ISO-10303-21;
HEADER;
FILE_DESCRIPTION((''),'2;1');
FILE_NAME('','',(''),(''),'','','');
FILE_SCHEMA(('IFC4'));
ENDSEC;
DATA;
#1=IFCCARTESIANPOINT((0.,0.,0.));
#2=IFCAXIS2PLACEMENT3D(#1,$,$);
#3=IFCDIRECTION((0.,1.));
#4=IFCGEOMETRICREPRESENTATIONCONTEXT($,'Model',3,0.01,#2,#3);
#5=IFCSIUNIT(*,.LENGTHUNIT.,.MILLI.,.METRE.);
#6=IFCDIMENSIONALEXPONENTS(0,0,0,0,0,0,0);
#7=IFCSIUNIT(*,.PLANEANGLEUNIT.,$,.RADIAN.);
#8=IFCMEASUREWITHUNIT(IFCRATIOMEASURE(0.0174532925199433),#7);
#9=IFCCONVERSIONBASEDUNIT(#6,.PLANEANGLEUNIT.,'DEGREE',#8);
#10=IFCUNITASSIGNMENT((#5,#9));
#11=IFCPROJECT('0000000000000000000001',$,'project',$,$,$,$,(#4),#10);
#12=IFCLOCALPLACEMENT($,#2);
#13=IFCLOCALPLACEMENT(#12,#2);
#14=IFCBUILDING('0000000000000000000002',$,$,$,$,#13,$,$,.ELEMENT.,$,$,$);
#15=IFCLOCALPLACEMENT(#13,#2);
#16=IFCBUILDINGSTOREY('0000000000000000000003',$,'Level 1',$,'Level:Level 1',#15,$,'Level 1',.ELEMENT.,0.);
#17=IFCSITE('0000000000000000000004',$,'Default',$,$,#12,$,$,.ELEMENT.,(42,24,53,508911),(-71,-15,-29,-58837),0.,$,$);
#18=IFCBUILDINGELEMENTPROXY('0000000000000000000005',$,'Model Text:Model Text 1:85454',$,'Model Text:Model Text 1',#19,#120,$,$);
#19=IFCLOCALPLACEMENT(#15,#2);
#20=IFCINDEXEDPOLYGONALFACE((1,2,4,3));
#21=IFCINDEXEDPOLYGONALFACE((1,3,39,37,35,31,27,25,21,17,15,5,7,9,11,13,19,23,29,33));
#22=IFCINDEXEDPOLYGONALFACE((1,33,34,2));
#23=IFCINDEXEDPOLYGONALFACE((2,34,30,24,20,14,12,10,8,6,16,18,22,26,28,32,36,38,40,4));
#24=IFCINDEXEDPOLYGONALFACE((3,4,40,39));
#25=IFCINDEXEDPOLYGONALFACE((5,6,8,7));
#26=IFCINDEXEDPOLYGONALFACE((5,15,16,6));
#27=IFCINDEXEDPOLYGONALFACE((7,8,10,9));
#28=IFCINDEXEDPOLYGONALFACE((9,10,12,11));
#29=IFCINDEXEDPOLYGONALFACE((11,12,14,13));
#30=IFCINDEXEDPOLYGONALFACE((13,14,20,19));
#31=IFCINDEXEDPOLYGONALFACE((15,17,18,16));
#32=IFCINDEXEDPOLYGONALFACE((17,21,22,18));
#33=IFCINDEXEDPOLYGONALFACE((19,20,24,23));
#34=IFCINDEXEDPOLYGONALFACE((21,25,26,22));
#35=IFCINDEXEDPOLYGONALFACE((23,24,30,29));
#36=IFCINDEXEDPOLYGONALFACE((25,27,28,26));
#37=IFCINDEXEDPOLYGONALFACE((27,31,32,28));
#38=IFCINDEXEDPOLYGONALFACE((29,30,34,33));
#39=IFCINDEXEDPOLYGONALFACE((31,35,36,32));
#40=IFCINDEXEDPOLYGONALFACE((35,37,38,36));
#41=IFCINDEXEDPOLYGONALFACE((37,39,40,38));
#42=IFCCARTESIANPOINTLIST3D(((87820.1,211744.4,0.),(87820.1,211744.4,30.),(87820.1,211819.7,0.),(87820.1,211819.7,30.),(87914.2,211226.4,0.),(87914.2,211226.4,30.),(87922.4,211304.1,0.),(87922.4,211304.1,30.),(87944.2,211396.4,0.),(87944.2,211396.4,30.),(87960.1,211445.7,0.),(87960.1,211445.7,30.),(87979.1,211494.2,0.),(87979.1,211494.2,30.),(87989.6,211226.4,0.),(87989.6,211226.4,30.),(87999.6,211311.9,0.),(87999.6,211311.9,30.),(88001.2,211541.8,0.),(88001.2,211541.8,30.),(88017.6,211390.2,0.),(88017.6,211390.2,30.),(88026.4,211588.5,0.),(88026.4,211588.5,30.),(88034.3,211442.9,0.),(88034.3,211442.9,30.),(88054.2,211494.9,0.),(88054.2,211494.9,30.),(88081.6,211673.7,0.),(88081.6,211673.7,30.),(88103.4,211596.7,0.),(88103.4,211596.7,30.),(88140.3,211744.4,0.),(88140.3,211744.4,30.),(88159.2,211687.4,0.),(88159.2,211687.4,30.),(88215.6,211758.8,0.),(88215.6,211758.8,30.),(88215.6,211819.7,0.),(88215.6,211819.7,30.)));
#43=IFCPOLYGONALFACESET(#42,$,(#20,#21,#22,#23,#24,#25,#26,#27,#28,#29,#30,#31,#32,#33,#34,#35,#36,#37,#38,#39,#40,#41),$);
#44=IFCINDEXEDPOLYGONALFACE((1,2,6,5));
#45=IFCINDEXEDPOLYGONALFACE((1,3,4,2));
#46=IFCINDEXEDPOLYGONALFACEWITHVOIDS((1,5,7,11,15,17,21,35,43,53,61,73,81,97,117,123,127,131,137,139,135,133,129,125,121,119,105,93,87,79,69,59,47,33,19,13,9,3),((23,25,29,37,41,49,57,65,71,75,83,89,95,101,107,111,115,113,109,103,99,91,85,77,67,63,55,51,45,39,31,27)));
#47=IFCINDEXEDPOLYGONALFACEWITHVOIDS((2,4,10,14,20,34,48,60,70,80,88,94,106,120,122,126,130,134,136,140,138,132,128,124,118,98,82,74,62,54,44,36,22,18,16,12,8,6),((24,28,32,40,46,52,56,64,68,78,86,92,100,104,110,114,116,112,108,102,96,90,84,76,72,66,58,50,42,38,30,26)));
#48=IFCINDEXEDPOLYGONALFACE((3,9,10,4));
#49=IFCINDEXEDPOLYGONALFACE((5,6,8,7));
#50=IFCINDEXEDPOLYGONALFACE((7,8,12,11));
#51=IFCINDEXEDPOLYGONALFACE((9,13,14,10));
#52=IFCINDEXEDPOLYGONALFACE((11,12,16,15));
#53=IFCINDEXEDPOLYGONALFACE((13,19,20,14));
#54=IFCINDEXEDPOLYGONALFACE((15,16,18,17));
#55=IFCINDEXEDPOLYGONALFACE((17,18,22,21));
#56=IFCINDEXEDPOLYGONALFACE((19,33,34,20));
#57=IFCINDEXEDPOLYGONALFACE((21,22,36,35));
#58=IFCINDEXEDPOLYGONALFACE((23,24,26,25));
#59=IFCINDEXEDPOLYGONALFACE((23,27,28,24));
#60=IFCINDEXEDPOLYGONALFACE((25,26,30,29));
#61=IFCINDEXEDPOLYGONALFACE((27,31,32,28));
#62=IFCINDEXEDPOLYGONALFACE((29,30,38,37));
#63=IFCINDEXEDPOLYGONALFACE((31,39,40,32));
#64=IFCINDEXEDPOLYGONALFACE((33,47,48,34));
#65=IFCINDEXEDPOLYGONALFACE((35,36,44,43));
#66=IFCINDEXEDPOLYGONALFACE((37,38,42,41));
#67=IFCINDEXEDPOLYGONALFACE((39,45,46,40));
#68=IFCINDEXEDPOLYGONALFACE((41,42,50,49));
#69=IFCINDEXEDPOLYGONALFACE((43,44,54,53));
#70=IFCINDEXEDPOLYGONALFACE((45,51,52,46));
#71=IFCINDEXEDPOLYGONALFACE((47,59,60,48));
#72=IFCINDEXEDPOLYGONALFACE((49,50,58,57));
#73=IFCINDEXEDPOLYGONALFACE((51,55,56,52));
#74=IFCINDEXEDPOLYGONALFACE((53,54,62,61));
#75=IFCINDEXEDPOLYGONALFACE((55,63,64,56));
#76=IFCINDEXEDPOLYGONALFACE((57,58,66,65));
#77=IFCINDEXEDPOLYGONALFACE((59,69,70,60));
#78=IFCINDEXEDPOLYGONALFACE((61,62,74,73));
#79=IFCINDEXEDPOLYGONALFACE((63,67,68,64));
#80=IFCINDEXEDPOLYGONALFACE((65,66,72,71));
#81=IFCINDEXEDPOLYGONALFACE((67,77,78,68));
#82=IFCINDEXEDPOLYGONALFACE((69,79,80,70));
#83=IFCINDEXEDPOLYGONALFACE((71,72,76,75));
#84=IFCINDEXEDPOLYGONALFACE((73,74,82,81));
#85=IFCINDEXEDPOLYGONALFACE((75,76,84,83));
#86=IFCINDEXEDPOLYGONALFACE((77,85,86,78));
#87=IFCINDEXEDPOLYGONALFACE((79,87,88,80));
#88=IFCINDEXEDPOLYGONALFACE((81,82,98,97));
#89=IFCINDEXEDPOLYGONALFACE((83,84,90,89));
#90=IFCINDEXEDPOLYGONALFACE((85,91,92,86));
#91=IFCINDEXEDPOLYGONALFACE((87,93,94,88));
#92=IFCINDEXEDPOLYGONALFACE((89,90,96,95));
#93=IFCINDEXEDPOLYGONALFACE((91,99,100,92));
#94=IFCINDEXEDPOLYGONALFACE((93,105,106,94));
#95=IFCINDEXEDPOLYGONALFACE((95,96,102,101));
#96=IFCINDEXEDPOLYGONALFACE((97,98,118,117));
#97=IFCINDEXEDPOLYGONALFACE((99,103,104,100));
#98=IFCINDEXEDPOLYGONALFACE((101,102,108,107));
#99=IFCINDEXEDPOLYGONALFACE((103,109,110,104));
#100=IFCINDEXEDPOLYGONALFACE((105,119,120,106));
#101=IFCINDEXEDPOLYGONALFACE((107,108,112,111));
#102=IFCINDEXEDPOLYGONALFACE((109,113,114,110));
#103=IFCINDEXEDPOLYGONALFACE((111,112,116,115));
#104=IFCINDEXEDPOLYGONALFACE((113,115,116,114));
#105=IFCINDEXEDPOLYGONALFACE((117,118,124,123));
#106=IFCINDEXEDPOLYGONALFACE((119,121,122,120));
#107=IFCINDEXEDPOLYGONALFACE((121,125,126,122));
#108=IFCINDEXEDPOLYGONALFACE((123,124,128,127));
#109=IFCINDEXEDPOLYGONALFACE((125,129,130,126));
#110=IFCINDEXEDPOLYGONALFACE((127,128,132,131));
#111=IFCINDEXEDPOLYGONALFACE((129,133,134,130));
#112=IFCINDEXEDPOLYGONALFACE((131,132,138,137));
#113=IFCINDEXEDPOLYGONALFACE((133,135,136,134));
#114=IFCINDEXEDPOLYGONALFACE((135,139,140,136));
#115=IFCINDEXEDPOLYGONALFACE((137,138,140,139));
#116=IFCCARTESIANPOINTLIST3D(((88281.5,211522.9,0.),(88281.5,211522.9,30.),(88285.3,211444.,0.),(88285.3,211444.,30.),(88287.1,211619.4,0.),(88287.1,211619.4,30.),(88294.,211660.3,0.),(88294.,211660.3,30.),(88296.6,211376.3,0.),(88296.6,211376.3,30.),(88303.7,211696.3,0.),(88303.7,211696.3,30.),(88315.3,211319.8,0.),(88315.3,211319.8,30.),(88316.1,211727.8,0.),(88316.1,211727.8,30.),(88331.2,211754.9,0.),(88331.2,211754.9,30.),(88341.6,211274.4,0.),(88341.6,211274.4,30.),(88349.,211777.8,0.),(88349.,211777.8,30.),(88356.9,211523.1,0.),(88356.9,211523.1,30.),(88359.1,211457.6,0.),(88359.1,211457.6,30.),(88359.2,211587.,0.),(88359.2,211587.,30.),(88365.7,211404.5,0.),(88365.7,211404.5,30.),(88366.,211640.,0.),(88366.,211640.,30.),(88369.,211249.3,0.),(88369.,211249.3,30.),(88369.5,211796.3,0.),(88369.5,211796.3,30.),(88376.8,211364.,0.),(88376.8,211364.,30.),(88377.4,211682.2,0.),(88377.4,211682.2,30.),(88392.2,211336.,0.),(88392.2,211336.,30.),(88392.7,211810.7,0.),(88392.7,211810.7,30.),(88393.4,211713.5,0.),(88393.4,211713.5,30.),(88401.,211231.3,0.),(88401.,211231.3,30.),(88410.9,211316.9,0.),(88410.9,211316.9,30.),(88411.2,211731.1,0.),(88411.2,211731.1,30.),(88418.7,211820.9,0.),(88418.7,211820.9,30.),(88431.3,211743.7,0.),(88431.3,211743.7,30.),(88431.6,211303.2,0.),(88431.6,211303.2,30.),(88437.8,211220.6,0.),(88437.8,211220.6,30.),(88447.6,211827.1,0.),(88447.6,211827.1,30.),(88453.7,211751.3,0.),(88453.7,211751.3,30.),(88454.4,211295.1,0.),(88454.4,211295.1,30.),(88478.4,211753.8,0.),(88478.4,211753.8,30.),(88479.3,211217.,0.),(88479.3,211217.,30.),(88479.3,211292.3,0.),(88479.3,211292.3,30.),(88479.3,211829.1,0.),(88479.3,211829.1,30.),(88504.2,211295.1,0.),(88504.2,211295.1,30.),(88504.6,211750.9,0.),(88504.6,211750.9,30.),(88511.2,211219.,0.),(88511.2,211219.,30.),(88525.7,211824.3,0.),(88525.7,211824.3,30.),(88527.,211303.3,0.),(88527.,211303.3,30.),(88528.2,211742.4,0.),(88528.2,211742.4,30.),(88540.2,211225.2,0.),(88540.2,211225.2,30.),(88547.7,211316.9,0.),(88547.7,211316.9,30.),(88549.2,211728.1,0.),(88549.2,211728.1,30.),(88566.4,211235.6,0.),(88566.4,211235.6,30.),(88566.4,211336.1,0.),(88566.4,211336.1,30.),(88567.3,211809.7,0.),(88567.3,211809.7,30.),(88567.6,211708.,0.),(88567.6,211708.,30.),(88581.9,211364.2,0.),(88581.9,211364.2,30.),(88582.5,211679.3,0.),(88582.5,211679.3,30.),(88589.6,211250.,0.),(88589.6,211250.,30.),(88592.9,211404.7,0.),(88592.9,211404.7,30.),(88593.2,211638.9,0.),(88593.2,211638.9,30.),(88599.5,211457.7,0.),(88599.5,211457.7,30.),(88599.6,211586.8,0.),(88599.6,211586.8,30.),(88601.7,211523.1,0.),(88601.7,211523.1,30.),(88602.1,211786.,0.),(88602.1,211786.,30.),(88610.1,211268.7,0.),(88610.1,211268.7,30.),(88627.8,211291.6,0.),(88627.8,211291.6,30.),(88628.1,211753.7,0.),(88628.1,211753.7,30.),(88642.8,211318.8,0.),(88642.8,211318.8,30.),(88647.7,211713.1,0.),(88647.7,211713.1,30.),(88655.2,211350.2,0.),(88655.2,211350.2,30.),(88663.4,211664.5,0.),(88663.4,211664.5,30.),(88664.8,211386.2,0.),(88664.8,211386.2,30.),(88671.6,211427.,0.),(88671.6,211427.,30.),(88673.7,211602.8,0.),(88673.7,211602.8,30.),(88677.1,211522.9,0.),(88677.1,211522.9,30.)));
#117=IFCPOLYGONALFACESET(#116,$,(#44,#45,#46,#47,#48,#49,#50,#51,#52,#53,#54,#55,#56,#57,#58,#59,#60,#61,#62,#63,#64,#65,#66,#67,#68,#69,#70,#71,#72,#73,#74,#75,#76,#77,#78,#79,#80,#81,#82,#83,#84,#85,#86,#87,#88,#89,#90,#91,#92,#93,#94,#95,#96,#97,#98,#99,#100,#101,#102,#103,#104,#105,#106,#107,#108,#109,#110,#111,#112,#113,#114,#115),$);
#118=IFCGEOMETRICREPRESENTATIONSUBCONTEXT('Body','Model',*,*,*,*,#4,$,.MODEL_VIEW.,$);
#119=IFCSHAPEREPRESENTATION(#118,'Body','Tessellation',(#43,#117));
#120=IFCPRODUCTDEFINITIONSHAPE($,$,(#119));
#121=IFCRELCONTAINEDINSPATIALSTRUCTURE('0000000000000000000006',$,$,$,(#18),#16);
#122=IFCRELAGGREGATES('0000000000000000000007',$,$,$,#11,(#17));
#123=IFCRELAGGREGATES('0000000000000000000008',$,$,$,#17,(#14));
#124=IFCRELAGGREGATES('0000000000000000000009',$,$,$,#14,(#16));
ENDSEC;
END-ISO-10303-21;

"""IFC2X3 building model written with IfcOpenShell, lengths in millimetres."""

from ifc_helpers import new_model, entity, si_unit, converted_unit, direction, frame, origin, place, context, subcontext, project, spatial, polyline, outline, extrude, element, save


model = new_model("IFC2X3")

# Units and contexts
model_context = context("Model", 3, precision=0.01, world=origin(), true_north=direction((0.0, 1.0)))
body_context = subcontext(model_context, "Body", "Model", "MODEL_VIEW")
ifc_project = project(units=[si_unit("LENGTHUNIT", "METRE", prefix="MILLI"), converted_unit("PLANEANGLEUNIT", "DEGREE", entity("IfcRatioMeasure", 0.0174532925199433), si_unit("PLANEANGLEUNIT", "RADIAN"), dimensions=[0, 0, 0, 0, 0, 0, 0])], contexts=[model_context])

# Site, building, storey
site_placement = place(None, origin())
site = spatial("IfcSite", under=ifc_project, at=site_placement, Name="Default", CompositionType="ELEMENT", RefLatitude=(42, 24, 53, 508911), RefLongitude=(-71, -15, -29, -58837), RefElevation=0.0)
building_placement = place(site_placement, origin())
building = spatial("IfcBuilding", under=site, at=building_placement, CompositionType="ELEMENT")
storey_placement = place(building_placement, origin())
storey = spatial("IfcBuildingStorey", under=building, at=storey_placement, Name="Level 1", ObjectType="Level:Level 1", LongName="Level 1", CompositionType="ELEMENT", Elevation=0.0)

# Building element proxy
proxy_1_placement = place(storey_placement, origin())
element("IfcBuildingElementProxy", 1, at=proxy_1_placement, inside=storey, Name="Model Text:Model Text 1:85454", ObjectType="Model Text:Model Text 1", context=body_context, shape_type="SweptSolid", body=[
    extrude(outline(polyline([(-199.9, -209.0), (-199.9, -284.3), (195.7, -284.3), (195.7, -223.4), (139.3, -152.0), (83.5, -61.3), (34.2, 40.5), (14.4, 92.5), (-2.4, 145.2), (-20.3, 223.5), (-30.3, 309.0), (-105.7, 309.0), (-97.5, 231.3), (-75.7, 139.0), (-59.9, 89.7), (-40.9, 41.2), (-18.8, -6.4), (6.4, -53.1), (61.7, -138.3), (120.3, -209.0), (-199.9, -209.0)])), frame((88019.9, 211535.4, 0.0), z_axis=(0.0, 0.0, -1.0), x_axis=(1.0, 0.0, 0.0)), (0.0, 0.0, -1.0), 30.0),
    extrude(outline(polyline([(-10.6, -198.7), (68.3, -198.7), (136.5, -190.7), (193.9, -174.7), (240.5, -150.6), (266.9, -124.4), (286.3, -93.2), (298.8, -57.0), (304.3, -15.7), (303.8, 16.2), (299.0, 45.5), (289.9, 72.1), (276.6, 96.0), (258.9, 117.3), (236.9, 136.2), (210.4, 152.5), (179.6, 166.3), (144.1, 177.6), (103.7, 186.3), (8.2, 196.4), (-71.8, 196.7), (-134.0, 189.4), (-183.3, 176.1), (-224.7, 158.4), (-258.2, 133.9), (-283.5, 100.3), (-300.1, 59.5), (-307.1, 13.4), (-306.6, -18.4), (-301.8, -47.5), (-292.8, -74.0), (-279.6, -97.9), (-262.0, -119.2), (-240.0, -138.1), (-213.6, -154.5), (-182.8, -168.4), (-147.3, -179.8), (-106.7, -188.6), (-10.6, -198.7)]), holes=[polyline([(-7.2, -123.5), (-71.0, -118.2), (-123.6, -108.8), (-165.2, -95.4), (-195.7, -78.0), (-212.4, -59.4), (-224.1, -38.7), (-230.6, -15.9), (-231.9, 8.9), (-227.8, 35.0), (-218.1, 58.1), (-202.8, 78.4), (-182.0, 95.8), (-152.6, 109.4), (-111.7, 118.1), (-59.4, 122.0), (4.4, 121.1), (69.6, 115.8), (122.2, 106.7), (162.2, 93.7), (189.5, 77.0), (207.7, 57.4), (220.4, 36.0), (227.5, 12.8), (229.1, -12.1), (225.2, -36.8), (215.9, -59.2), (201.3, -79.3), (181.4, -97.1), (152.6, -111.2), (111.6, -120.3), (58.3, -124.4), (-7.2, -123.5)])]), frame((88480.6, 211521.7, 0.0), z_axis=(0.0, 0.0, 1.0), x_axis=(0.047515, -0.998871, 0.0)), (0.0, 0.0, 1.0), 30.0),
])

save(model, "model.ifc")
